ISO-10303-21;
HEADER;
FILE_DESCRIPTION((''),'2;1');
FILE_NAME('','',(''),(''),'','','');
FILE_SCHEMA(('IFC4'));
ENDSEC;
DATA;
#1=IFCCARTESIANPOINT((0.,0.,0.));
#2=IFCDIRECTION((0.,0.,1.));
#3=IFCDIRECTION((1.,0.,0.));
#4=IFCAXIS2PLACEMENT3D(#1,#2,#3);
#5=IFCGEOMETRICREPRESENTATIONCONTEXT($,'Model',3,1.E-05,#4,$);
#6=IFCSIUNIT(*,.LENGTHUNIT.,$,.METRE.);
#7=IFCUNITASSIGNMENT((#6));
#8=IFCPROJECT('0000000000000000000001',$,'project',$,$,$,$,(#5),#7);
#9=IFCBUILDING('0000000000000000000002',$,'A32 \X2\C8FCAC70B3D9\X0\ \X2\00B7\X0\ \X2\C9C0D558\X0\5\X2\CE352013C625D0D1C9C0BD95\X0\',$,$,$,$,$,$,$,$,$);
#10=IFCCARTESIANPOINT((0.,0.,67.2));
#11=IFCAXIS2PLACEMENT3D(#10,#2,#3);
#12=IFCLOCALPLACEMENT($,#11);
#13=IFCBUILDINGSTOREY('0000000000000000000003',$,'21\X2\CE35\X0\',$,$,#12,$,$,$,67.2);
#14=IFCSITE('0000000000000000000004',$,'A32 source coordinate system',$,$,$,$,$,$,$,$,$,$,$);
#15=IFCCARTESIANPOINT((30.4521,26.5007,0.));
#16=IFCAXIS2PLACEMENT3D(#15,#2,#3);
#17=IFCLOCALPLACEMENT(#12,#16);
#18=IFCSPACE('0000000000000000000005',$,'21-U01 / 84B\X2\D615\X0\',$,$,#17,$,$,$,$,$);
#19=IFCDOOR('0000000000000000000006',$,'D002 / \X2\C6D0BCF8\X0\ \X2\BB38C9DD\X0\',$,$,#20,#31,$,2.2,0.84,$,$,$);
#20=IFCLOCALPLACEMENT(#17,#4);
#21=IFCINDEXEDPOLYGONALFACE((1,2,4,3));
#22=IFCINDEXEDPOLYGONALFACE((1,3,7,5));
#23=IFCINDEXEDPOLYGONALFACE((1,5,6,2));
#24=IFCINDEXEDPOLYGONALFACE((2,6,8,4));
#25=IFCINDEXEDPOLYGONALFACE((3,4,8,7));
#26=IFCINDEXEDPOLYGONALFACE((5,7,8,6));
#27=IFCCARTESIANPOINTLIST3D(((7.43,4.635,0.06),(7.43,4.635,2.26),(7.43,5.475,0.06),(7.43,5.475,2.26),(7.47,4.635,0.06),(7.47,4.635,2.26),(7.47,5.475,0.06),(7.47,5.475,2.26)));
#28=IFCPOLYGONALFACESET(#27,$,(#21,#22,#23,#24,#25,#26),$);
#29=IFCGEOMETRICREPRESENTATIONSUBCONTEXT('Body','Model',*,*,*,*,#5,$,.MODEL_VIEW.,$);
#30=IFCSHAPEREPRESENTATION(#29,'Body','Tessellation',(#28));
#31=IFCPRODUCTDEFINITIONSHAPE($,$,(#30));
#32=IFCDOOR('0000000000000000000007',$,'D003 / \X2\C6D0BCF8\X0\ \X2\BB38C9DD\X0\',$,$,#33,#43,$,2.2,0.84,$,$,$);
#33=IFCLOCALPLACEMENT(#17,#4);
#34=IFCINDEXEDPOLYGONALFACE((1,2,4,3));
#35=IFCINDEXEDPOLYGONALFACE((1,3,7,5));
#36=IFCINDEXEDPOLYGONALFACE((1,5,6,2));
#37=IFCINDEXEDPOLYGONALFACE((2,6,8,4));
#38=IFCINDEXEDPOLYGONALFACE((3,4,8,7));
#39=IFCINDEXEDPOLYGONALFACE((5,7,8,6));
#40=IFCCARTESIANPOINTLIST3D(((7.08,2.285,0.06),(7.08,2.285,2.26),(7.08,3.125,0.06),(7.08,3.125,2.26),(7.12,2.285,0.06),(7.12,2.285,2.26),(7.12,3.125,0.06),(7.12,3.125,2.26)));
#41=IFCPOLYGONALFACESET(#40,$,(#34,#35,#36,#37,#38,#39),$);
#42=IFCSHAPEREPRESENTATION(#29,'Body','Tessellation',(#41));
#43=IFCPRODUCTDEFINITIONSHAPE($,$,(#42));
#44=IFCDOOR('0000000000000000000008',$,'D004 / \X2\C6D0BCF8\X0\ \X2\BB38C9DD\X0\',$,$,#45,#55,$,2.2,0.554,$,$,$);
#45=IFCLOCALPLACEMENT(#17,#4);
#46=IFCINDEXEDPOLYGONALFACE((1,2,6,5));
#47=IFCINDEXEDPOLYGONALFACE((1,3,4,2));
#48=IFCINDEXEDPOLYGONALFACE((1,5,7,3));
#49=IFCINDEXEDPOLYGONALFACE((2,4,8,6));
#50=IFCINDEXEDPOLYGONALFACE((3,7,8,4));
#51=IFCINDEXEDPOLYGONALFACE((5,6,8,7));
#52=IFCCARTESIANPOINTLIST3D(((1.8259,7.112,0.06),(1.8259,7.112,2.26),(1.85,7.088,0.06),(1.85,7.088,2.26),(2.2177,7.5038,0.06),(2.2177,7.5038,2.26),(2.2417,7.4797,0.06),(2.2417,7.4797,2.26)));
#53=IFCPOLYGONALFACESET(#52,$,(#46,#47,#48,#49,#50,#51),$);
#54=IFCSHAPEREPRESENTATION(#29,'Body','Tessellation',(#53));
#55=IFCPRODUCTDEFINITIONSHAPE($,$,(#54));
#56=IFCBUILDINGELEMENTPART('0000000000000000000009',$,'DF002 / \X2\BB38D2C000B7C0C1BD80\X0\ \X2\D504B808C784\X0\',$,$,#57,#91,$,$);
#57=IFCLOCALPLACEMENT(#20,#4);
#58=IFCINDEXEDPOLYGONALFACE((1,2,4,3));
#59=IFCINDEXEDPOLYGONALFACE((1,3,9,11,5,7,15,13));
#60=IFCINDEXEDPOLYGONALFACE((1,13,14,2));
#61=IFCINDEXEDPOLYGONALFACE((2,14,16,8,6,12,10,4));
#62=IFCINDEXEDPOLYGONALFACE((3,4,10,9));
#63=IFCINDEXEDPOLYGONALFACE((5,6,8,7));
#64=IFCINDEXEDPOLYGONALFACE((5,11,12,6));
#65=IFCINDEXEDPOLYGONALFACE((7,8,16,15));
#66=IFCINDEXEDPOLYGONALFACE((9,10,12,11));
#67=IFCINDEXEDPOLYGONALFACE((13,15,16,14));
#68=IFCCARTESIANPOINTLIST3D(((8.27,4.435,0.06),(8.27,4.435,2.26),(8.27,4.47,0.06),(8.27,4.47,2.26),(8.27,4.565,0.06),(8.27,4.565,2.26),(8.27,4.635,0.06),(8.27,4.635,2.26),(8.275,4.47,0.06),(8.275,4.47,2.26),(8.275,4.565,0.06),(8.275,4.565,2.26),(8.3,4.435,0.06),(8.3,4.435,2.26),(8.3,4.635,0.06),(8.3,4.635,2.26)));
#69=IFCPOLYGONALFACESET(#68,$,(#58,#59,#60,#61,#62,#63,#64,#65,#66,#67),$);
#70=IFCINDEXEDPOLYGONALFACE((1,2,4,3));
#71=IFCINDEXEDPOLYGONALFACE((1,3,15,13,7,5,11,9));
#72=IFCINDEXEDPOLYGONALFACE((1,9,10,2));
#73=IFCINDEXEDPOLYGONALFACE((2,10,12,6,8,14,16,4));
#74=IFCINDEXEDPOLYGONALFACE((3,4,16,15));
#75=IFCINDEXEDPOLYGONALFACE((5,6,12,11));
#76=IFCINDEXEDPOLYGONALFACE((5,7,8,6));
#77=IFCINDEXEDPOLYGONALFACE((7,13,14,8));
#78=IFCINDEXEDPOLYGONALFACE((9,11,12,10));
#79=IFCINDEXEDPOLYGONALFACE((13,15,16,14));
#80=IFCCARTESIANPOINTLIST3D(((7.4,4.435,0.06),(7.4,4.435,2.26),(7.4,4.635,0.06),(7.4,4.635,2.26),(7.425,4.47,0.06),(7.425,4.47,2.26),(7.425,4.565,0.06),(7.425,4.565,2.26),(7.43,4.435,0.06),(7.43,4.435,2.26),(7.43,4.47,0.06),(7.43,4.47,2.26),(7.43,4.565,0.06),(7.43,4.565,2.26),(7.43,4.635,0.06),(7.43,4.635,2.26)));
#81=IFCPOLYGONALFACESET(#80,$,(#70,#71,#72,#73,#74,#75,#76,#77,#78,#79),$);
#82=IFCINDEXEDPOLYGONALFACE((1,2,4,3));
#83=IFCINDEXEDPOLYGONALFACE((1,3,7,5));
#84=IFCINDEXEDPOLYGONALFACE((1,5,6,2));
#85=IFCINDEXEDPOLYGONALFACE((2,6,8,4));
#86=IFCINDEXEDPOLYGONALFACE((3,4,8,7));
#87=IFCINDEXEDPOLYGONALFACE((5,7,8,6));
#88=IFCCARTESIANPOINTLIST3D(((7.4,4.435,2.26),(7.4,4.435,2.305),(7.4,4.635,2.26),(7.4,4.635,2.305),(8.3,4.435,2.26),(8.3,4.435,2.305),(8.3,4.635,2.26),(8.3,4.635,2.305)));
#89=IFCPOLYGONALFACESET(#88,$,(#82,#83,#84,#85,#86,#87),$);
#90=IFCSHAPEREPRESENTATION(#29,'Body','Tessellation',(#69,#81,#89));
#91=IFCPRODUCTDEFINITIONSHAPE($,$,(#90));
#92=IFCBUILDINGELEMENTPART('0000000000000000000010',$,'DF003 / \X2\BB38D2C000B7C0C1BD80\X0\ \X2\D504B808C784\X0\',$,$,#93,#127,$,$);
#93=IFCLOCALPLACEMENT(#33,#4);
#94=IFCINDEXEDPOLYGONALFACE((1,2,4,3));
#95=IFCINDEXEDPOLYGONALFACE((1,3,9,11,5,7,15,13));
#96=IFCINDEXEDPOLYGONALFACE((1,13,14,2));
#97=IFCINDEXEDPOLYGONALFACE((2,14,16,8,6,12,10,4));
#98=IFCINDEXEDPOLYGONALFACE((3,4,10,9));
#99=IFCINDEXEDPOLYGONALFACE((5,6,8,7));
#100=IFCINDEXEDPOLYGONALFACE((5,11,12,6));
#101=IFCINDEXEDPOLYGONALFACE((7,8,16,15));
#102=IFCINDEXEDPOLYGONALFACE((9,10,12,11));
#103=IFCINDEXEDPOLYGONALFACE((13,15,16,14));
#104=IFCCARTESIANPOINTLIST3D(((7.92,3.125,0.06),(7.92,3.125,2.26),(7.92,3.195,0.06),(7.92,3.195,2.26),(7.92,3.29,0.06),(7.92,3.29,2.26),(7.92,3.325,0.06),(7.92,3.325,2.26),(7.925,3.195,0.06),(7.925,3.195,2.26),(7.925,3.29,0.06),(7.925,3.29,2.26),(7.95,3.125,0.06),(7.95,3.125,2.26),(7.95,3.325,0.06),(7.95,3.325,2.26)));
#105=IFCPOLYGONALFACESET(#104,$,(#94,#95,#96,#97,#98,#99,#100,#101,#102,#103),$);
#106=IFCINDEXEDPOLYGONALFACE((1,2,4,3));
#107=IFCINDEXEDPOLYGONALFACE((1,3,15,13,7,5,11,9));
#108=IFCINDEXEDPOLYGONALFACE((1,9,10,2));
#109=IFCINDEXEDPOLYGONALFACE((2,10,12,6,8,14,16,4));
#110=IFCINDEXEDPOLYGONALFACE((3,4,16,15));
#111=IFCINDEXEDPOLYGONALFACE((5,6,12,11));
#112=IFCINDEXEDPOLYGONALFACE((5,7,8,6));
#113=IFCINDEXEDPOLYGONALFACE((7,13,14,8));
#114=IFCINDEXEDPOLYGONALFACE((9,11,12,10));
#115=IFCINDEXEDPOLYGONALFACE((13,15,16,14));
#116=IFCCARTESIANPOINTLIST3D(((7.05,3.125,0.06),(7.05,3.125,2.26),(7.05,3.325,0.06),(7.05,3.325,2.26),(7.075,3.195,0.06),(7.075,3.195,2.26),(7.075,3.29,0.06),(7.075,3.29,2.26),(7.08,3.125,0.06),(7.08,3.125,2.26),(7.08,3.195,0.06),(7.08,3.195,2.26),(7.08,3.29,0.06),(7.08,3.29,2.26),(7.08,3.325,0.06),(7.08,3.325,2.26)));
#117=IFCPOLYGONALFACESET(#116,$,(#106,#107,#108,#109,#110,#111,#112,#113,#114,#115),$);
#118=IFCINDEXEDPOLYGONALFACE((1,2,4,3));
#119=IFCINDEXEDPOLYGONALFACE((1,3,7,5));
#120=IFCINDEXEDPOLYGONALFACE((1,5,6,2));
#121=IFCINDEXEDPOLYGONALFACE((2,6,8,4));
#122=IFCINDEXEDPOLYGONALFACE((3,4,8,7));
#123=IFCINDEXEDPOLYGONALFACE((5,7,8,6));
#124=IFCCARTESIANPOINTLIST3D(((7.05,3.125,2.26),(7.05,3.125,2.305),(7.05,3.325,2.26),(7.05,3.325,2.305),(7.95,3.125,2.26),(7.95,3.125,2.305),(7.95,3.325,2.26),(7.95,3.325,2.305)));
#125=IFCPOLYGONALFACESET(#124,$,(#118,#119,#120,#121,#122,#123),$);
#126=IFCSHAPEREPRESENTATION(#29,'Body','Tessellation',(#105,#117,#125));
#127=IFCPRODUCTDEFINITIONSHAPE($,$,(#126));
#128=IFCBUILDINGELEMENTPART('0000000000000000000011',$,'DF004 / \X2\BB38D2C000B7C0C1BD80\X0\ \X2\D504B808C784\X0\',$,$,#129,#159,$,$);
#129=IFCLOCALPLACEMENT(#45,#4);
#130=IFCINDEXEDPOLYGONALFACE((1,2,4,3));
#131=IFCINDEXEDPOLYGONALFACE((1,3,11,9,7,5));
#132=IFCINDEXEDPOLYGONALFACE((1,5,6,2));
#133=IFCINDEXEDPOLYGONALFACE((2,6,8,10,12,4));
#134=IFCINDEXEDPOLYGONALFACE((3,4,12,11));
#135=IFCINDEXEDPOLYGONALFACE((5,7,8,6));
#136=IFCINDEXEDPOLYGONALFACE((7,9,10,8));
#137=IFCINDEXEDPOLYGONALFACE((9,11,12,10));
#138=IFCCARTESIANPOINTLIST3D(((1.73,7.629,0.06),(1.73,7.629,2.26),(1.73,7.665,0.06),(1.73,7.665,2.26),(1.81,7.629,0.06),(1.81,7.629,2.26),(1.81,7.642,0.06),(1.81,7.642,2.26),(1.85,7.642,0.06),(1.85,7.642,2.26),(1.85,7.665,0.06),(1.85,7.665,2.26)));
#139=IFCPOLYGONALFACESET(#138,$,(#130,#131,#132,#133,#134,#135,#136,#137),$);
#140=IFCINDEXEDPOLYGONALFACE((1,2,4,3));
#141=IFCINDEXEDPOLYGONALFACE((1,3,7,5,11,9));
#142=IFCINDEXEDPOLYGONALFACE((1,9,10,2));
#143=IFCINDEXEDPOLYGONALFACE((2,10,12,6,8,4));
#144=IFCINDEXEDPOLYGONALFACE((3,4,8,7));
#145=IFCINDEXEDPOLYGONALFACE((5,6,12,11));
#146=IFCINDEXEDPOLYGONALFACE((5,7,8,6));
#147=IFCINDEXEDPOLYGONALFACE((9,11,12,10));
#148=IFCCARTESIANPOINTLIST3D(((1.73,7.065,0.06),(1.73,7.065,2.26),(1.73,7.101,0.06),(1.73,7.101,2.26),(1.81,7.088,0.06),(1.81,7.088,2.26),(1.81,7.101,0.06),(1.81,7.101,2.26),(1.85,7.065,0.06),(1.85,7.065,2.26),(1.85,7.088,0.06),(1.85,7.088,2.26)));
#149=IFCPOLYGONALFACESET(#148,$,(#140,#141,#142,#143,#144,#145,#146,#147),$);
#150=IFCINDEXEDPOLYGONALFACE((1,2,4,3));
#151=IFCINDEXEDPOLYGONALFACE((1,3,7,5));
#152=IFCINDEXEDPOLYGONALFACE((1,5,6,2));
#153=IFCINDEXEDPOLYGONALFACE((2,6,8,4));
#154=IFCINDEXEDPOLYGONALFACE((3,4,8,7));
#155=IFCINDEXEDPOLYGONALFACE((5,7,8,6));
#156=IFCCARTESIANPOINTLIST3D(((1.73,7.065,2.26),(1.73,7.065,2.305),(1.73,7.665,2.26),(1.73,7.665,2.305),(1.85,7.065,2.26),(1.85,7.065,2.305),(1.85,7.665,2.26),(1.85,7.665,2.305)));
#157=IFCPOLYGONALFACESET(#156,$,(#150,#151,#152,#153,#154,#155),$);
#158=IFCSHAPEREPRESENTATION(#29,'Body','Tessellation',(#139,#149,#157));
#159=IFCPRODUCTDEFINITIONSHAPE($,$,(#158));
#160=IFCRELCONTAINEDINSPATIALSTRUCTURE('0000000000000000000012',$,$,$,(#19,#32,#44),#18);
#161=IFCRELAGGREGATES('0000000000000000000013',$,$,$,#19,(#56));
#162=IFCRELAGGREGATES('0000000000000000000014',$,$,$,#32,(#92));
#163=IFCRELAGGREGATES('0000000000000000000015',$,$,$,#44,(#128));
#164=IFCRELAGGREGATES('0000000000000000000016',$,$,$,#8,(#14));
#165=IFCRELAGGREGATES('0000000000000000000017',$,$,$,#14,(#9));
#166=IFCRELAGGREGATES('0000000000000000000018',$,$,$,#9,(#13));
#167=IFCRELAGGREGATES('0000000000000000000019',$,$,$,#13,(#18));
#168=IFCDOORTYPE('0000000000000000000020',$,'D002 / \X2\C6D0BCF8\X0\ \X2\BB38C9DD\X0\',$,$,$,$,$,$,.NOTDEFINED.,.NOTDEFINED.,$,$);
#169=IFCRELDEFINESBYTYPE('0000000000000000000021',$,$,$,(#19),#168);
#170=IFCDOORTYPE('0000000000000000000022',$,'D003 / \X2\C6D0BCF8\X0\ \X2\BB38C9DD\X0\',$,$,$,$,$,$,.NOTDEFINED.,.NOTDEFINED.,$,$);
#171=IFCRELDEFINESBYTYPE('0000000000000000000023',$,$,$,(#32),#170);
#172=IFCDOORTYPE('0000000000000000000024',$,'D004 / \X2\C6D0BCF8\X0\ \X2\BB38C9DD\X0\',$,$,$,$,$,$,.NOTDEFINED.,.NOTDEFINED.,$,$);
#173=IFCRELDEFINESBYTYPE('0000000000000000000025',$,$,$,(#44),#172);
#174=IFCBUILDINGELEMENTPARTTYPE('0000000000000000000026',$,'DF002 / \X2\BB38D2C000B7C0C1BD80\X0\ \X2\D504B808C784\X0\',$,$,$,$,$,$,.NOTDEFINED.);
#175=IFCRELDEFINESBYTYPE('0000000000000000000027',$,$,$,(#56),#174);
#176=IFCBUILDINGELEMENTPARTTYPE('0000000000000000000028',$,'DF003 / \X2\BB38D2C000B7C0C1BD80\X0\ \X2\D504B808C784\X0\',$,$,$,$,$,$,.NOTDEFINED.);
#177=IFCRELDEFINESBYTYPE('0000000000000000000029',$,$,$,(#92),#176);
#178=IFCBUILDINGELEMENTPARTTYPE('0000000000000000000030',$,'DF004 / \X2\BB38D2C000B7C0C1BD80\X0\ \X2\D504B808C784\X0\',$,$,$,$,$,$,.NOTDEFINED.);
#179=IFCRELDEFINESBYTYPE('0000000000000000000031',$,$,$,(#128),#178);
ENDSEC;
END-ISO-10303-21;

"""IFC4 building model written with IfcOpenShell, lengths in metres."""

from ifc_helpers import new_model, si_unit, frame, origin, origin_with_axes, place, context, subcontext, project, spatial, polyline, outline, extrude, source, transform, mapped, type_object, type_shapes, element, aggregate, save


model = new_model("IFC4")

# Units and contexts
model_context = context("Model", 3, precision=1e-05, world=origin_with_axes())
body_context = subcontext(model_context, "Body", "Model", "MODEL_VIEW")
ifc_project = project(units=[si_unit("LENGTHUNIT", "METRE")], contexts=[model_context])

# Site, building, storey, space
storey_placement = place(None, frame((0.0, 0.0, 67.2), z_axis=(0.0, 0.0, 1.0), x_axis=(1.0, 0.0, 0.0)))
space_placement = place(storey_placement, frame((30.4521, 26.5007, 0.0), z_axis=(0.0, 0.0, 1.0), x_axis=(1.0, 0.0, 0.0)))
site = spatial("IfcSite", under=ifc_project, Name="A32 source coordinate system")
building = spatial("IfcBuilding", under=site, Name="A32 주거동 · 지하5층–옥탑지붕")
storey = spatial("IfcBuildingStorey", under=building, at=storey_placement, Name="21층", Elevation=67.2)
space = spatial("IfcSpace", under=storey, at=space_placement, Name="21-U01 / 84B형")

# Doors
door_type_1 = type_object("IfcDoorType", Name="D002 / 원본 문짝", OperationType="NOTDEFINED", PredefinedType="NOTDEFINED")
shared_shape_1 = source(origin(), body_context, "Body", "SweptSolid", [
    extrude(outline(polyline([(7.43, 4.635), (7.43, 5.475), (7.47, 5.475), (7.47, 4.635), (7.43, 4.635)])), frame((0.0, 0.0, 0.06)), (0.0, 0.0, 1.0), 2.2),
])
type_shapes(door_type_1, [shared_shape_1])
door_1_placement = place(space_placement, origin_with_axes())
door_1 = element("IfcDoor", 1, at=door_1_placement, inside=space, type_object=door_type_1, Name="D002 / 원본 문짝", OverallHeight=2.2, OverallWidth=0.84, context=body_context, shape_type="MappedRepresentation", body=[
    mapped(shared_shape_1, transform((0.0, 0.0, 0.0), scale=1.0)),
])
door_type_2 = type_object("IfcDoorType", Name="D003 / 원본 문짝", OperationType="NOTDEFINED", PredefinedType="NOTDEFINED")
shared_shape_2 = source(origin(), body_context, "Body", "SweptSolid", [
    extrude(outline(polyline([(7.12, 2.285), (7.08, 2.285), (7.08, 3.125), (7.12, 3.125), (7.12, 2.285)])), frame((0.0, 0.0, 0.06)), (0.0, 0.0, 1.0), 2.2),
])
type_shapes(door_type_2, [shared_shape_2])
door_2_placement = place(space_placement, origin_with_axes())
door_2 = element("IfcDoor", 2, at=door_2_placement, inside=space, type_object=door_type_2, Name="D003 / 원본 문짝", OverallHeight=2.2, OverallWidth=0.84, context=body_context, shape_type="MappedRepresentation", body=[
    mapped(shared_shape_2, transform((0.0, 0.0, 0.0), scale=1.0)),
])
door_type_3 = type_object("IfcDoorType", Name="D004 / 원본 문짝", OperationType="NOTDEFINED", PredefinedType="NOTDEFINED")
shared_shape_3 = source(origin(), body_context, "Body", "SweptSolid", [
    extrude(outline(polyline([(2.2177, 7.5038), (2.2417, 7.4797), (1.85, 7.088), (1.8259, 7.112), (2.2177, 7.5038)])), frame((0.0, 0.0, 0.06)), (0.0, 0.0, 1.0), 2.2),
])
type_shapes(door_type_3, [shared_shape_3])
door_3_placement = place(space_placement, origin_with_axes())
door_3 = element("IfcDoor", 3, at=door_3_placement, inside=space, type_object=door_type_3, Name="D004 / 원본 문짝", OverallHeight=2.2, OverallWidth=0.554, context=body_context, shape_type="MappedRepresentation", body=[
    mapped(shared_shape_3, transform((0.0, 0.0, 0.0), scale=1.0)),
])

# Building element parts
building_element_part_type_1 = type_object("IfcBuildingElementPartType", Name="DF002 / 문틀·상부 프레임", PredefinedType="NOTDEFINED")
shared_shape_4 = source(origin(), body_context, "Body", "SweptSolid", [
    extrude(outline(polyline([(8.3, 4.435), (8.27, 4.435), (8.27, 4.47), (8.275, 4.47), (8.275, 4.565), (8.27, 4.565), (8.27, 4.635), (8.3, 4.635), (8.3, 4.435)])), frame((0.0, 0.0, 0.06)), (0.0, 0.0, 1.0), 2.2),
    extrude(outline(polyline([(7.43, 4.635), (7.43, 4.565), (7.425, 4.565), (7.425, 4.47), (7.43, 4.47), (7.43, 4.435), (7.4, 4.435), (7.4, 4.635), (7.43, 4.635)])), frame((0.0, 0.0, 0.06)), (0.0, 0.0, 1.0), 2.2),
    extrude(outline(polyline([(7.4, 4.435), (7.4, 4.635), (8.3, 4.635), (8.3, 4.435), (7.4, 4.435)])), frame((0.0, 0.0, 2.26)), (0.0, 0.0, 1.0), 0.045),
])
type_shapes(building_element_part_type_1, [shared_shape_4])
building_element_part_1_placement = place(door_1_placement, origin_with_axes())
building_element_part_1 = element("IfcBuildingElementPart", 4, at=building_element_part_1_placement, type_object=building_element_part_type_1, Name="DF002 / 문틀·상부 프레임", context=body_context, shape_type="MappedRepresentation", body=[
    mapped(shared_shape_4, transform((0.0, 0.0, 0.0), scale=1.0)),
])
aggregate(door_1, [building_element_part_1])
building_element_part_type_2 = type_object("IfcBuildingElementPartType", Name="DF003 / 문틀·상부 프레임", PredefinedType="NOTDEFINED")
shared_shape_5 = source(origin(), body_context, "Body", "SweptSolid", [
    extrude(outline(polyline([(7.92, 3.125), (7.92, 3.195), (7.925, 3.195), (7.925, 3.29), (7.92, 3.29), (7.92, 3.325), (7.95, 3.325), (7.95, 3.125), (7.92, 3.125)])), frame((0.0, 0.0, 0.06)), (0.0, 0.0, 1.0), 2.2),
    extrude(outline(polyline([(7.05, 3.325), (7.08, 3.325), (7.08, 3.29), (7.075, 3.29), (7.075, 3.195), (7.08, 3.195), (7.08, 3.125), (7.05, 3.125), (7.05, 3.325)])), frame((0.0, 0.0, 0.06)), (0.0, 0.0, 1.0), 2.2),
    extrude(outline(polyline([(7.05, 3.125), (7.05, 3.325), (7.95, 3.325), (7.95, 3.125), (7.05, 3.125)])), frame((0.0, 0.0, 2.26)), (0.0, 0.0, 1.0), 0.045),
])
type_shapes(building_element_part_type_2, [shared_shape_5])
building_element_part_2_placement = place(door_2_placement, origin_with_axes())
building_element_part_2 = element("IfcBuildingElementPart", 5, at=building_element_part_2_placement, type_object=building_element_part_type_2, Name="DF003 / 문틀·상부 프레임", context=body_context, shape_type="MappedRepresentation", body=[
    mapped(shared_shape_5, transform((0.0, 0.0, 0.0), scale=1.0)),
])
aggregate(door_2, [building_element_part_2])
building_element_part_type_3 = type_object("IfcBuildingElementPartType", Name="DF004 / 문틀·상부 프레임", PredefinedType="NOTDEFINED")
shared_shape_6 = source(origin(), body_context, "Body", "SweptSolid", [
    extrude(outline(polyline([(1.85, 7.665), (1.85, 7.642), (1.81, 7.642), (1.81, 7.629), (1.73, 7.629), (1.73, 7.665), (1.85, 7.665)])), frame((0.0, 0.0, 0.06)), (0.0, 0.0, 1.0), 2.2),
    extrude(outline(polyline([(1.73, 7.101), (1.81, 7.101), (1.81, 7.088), (1.85, 7.088), (1.85, 7.065), (1.73, 7.065), (1.73, 7.101)])), frame((0.0, 0.0, 0.06)), (0.0, 0.0, 1.0), 2.2),
    extrude(outline(polyline([(1.73, 7.065), (1.73, 7.665), (1.85, 7.665), (1.85, 7.065), (1.73, 7.065)])), frame((0.0, 0.0, 2.26)), (0.0, 0.0, 1.0), 0.045),
])
type_shapes(building_element_part_type_3, [shared_shape_6])
building_element_part_3_placement = place(door_3_placement, origin_with_axes())
building_element_part_3 = element("IfcBuildingElementPart", 6, at=building_element_part_3_placement, type_object=building_element_part_type_3, Name="DF004 / 문틀·상부 프레임", context=body_context, shape_type="MappedRepresentation", body=[
    mapped(shared_shape_6, transform((0.0, 0.0, 0.0), scale=1.0)),
])
aggregate(door_3, [building_element_part_3])

save(model, "model.ifc")
